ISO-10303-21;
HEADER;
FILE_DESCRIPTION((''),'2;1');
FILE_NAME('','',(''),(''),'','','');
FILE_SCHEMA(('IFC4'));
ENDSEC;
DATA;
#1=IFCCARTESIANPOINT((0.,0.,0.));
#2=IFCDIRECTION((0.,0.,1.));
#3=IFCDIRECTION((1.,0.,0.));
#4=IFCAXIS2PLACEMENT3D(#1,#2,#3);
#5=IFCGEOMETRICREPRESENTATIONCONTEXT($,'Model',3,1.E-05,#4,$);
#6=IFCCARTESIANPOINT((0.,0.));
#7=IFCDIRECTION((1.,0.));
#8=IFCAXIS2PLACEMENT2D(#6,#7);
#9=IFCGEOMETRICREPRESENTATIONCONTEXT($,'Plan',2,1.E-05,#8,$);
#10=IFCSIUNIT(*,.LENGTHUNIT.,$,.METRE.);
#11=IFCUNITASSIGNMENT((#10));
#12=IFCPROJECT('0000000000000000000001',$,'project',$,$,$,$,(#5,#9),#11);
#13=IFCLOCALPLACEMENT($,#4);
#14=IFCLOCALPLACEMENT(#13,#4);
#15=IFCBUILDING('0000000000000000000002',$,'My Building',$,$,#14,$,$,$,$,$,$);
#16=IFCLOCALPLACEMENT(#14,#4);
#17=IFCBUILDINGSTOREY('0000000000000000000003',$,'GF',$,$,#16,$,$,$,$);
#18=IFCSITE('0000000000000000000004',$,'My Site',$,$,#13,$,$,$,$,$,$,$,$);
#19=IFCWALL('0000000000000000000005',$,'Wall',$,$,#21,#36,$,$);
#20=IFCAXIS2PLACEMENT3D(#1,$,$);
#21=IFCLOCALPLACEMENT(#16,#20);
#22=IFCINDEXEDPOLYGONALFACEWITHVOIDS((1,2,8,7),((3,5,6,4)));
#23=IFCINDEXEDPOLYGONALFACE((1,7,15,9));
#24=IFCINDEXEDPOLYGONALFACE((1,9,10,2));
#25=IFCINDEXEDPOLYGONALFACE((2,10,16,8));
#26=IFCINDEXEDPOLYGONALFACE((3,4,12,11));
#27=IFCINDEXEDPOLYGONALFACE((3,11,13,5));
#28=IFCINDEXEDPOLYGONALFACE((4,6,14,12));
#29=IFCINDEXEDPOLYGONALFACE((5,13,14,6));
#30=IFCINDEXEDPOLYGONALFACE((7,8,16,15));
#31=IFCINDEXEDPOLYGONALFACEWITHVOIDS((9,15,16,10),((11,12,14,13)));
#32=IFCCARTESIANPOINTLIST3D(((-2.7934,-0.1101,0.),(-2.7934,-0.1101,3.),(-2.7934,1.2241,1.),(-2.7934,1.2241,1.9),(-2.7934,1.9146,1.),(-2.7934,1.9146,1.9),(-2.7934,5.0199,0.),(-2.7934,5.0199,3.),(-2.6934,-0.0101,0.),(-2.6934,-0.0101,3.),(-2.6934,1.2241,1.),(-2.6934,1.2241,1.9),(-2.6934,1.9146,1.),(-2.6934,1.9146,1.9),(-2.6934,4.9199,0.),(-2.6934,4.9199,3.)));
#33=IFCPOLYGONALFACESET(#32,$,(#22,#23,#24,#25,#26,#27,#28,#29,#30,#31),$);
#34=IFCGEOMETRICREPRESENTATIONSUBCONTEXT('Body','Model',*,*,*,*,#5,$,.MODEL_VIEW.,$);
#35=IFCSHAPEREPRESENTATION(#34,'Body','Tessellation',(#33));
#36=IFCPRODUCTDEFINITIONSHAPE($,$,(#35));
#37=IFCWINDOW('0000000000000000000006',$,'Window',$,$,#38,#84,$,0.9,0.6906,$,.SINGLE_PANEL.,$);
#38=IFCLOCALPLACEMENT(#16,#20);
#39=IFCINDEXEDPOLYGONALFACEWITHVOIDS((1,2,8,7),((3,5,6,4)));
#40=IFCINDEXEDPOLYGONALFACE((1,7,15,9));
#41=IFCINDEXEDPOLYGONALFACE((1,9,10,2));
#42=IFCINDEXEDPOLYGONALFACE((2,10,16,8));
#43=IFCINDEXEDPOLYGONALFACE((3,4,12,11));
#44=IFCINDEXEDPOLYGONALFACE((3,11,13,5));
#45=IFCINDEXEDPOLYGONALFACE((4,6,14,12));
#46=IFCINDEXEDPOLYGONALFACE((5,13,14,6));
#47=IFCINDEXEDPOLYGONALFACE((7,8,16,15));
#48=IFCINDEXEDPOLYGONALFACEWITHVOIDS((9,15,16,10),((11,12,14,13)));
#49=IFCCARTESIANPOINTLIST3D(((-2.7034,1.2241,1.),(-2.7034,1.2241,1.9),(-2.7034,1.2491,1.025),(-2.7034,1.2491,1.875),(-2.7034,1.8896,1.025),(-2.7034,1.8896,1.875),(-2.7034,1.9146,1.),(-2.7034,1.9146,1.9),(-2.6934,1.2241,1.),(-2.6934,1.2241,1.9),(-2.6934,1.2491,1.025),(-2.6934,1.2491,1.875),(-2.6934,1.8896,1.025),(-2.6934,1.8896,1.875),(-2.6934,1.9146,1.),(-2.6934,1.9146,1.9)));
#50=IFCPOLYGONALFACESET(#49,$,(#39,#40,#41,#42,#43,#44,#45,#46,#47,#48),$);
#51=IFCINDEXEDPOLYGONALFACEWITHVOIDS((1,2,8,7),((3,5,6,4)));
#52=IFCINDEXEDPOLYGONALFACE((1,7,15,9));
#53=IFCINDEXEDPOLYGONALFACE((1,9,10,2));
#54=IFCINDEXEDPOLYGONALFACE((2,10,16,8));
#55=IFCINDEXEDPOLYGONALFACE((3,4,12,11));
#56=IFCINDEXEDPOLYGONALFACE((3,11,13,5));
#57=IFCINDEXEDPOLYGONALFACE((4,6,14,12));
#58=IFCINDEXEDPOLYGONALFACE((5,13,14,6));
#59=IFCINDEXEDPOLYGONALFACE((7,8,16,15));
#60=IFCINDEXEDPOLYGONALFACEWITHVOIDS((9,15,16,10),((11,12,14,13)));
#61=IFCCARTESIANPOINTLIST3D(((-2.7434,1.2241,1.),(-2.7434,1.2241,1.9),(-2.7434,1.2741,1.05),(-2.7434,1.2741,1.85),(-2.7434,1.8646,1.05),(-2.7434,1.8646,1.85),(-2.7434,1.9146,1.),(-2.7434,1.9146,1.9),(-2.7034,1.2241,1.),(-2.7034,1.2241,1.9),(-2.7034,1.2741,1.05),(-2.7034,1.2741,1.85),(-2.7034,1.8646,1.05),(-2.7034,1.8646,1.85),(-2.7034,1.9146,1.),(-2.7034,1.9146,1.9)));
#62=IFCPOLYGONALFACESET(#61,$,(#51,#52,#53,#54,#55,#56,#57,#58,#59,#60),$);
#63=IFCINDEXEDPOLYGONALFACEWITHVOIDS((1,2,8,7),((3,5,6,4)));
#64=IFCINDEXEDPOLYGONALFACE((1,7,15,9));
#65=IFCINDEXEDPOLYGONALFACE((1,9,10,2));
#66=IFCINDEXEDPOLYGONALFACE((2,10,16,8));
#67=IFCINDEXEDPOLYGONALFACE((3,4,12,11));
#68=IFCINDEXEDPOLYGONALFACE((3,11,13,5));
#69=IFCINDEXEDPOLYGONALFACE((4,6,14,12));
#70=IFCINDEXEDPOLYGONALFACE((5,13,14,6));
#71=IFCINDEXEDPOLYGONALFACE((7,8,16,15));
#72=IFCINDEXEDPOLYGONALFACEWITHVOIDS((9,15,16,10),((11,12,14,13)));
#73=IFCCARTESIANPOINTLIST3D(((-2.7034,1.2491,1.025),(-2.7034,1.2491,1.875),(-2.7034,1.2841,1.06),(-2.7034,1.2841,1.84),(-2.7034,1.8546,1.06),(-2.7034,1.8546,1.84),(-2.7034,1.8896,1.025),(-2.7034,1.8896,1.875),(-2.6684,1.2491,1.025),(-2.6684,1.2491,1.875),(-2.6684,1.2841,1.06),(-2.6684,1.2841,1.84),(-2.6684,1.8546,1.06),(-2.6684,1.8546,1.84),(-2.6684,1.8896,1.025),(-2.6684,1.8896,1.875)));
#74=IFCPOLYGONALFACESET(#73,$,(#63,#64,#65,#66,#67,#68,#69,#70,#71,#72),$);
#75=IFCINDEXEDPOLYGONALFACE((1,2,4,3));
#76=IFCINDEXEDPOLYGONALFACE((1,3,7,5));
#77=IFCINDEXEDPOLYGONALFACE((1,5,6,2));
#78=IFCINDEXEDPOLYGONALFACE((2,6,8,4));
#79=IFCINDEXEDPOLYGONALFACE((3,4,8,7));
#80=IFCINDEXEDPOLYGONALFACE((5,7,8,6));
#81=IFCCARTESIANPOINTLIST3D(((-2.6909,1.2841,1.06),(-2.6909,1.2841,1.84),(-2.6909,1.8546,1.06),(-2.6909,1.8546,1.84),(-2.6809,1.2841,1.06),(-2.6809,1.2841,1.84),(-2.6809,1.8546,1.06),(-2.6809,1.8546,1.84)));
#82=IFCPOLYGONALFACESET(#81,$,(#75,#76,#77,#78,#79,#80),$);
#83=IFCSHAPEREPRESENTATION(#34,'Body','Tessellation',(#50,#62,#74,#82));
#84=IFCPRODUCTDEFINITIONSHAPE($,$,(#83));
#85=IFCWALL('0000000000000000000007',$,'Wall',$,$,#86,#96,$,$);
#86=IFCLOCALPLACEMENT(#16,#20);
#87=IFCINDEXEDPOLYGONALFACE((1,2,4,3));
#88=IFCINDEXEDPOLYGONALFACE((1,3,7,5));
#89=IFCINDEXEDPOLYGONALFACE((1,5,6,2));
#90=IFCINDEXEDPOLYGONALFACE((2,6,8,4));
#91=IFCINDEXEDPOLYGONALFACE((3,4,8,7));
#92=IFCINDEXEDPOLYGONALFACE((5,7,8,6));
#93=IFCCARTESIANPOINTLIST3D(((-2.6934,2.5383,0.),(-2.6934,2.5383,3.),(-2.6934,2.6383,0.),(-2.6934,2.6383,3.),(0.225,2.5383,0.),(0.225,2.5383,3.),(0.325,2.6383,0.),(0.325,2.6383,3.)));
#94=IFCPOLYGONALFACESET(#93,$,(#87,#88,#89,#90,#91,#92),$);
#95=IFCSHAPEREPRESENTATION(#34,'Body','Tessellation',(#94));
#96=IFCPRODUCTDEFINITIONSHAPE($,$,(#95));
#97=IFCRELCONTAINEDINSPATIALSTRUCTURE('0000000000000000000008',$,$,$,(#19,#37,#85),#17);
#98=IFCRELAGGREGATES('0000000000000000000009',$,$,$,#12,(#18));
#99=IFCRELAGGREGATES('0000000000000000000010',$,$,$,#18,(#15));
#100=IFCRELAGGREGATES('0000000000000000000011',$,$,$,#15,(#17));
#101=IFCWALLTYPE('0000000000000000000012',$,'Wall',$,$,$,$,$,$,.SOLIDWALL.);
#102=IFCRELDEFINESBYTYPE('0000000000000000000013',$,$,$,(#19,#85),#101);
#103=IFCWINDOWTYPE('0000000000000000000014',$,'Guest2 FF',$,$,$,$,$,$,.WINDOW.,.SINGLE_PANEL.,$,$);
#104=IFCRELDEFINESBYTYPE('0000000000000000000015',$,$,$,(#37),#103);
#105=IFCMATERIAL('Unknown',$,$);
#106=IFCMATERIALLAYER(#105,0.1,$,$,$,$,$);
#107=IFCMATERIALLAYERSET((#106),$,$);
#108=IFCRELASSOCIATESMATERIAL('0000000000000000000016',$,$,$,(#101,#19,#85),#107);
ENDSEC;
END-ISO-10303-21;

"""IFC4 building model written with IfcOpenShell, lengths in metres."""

from ifc_helpers import new_model, entity, si_unit, frame, origin_with_axes, origin_2d_with_axis, place, context, subcontext, project, spatial, line, indexed_curve, outline, extrude, shape, source, transform, mapped, material, layer, layer_set, layer_usage, type_object, type_shapes, element, fill, save


model = new_model("IFC4")

# Units and contexts
model_context = context("Model", 3, precision=1e-05, world=origin_with_axes())
plan_context = context("Plan", 2, precision=1e-05, world=origin_2d_with_axis())
body_context_1 = subcontext(model_context, "Body", "Model", "MODEL_VIEW")
body_context_2 = subcontext(plan_context, "Body", "Plan", "PLAN_VIEW")
ifc_project = project(units=[si_unit("LENGTHUNIT", "METRE")], contexts=[model_context, plan_context])

# Site, building, storey
site_placement = place(None, origin_with_axes())
site = spatial("IfcSite", under=ifc_project, at=site_placement, Name="My Site")
building_placement = place(site_placement, origin_with_axes())
building = spatial("IfcBuilding", under=site, at=building_placement, Name="My Building")
storey_placement = place(building_placement, origin_with_axes())
storey = spatial("IfcBuildingStorey", under=building, at=storey_placement, Name="GF")

# Shared definitions
ifc_material_1 = material(Name="Unknown")

# Shared definitions
ifc_layer_1 = layer(ifc_material_1, 0.1)
ifc_layer_set_1 = layer_set([ifc_layer_1])
wall_type = type_object("IfcWallType", Name="Wall", PredefinedType="SOLIDWALL", material=ifc_layer_set_1)

# Wall, opening, window
ifc_layer_usage_1 = layer_usage(ifc_layer_set_1, "AXIS2", "POSITIVE", 0.0)
wall_1_placement = place(storey_placement, frame((-2.7934, 5.0199, 0.0), z_axis=(0.0, 0.0, 1.0), x_axis=(0.0, -1.0, 0.0)))
wall_1 = element("IfcWall", 1, at=wall_1_placement, inside=storey, type_object=wall_type, material=ifc_layer_usage_1, Name="Wall", context=body_context_1, shape_type="SweptSolid", body=[
    extrude(outline(indexed_curve([(0.0, 0.0), (0.1, 0.1), (5.03, 0.1), (5.13, 0.0)], segments=[line(1, 2, 3, 4, 1)])), origin_with_axes(), (0.0, 0.0, 1.0), 3.0),
])
shared_shape_1 = source(origin_with_axes(), body_context_1, "Body", "SweptSolid", [
    extrude(outline(indexed_curve([(0.0, 0.0), (0.6906, 0.0), (0.6906, 0.9), (0.0, 0.9)], segments=[line(1, 2, 3, 4, 1)])), frame((0.0, -0.6, 0.0), z_axis=(0.0, -1.0, 0.0), x_axis=(1.0, 0.0, 0.0)), (0.0, 0.0, -1.0), 1.2),
])
opening_1_placement = place(wall_1_placement, frame((3.1053, 0.0, 1.0), z_axis=(0.0, 0.0, 1.0), x_axis=(1.0, 0.0, 0.0)))
opening_1 = element("IfcOpeningElement", 2, at=opening_1_placement, cuts=wall_1, PredefinedType="OPENING", context=body_context_1, shape_type="MappedRepresentation", body=[
    mapped(shared_shape_1, transform((0.0, 0.0, 0.0), x_axis=(1.0, 0.0, 0.0), y_axis=(0.0, 1.0, 0.0), z_axis=(0.0, 0.0, 1.0), scale=1.0)),
])
window_type_1 = type_object("IfcWindowType", Name="Guest2 FF", PartitioningType="SINGLE_PANEL", PredefinedType="WINDOW")
shared_shape_2 = source(origin_with_axes(), body_context_1, "Body", "SweptSolid", [
    extrude(outline(indexed_curve([(0.0, 0.0), (0.6906, 0.0), (0.6906, 0.9), (0.0, 0.9)], segments=[line(1, 2, 3, 4, 1)]), holes=[indexed_curve([(0.025, 0.025), (0.6656, 0.025), (0.6656, 0.875), (0.025, 0.875)], segments=[line(1, 2, 3, 4, 1)])]), frame((0.0, 0.09, 0.0), z_axis=(0.0, -1.0, 0.0), x_axis=(1.0, 0.0, 0.0)), (0.0, 0.0, -1.0), 0.01),
    extrude(outline(indexed_curve([(0.0, 0.0), (0.6906, 0.0), (0.6906, 0.9), (0.0, 0.9)], segments=[line(1, 2, 3, 4, 1)]), holes=[indexed_curve([(0.05, 0.05), (0.6406, 0.05), (0.6406, 0.85), (0.05, 0.85)], segments=[line(1, 2, 3, 4, 1)])]), frame((0.0, 0.05, 0.0), z_axis=(0.0, -1.0, 0.0), x_axis=(1.0, 0.0, 0.0)), (0.0, 0.0, -1.0), 0.04),
    extrude(outline(indexed_curve([(0.0, 0.0), (0.6406, 0.0), (0.6406, 0.85), (0.0, 0.85)], segments=[line(1, 2, 3, 4, 1)]), holes=[indexed_curve([(0.035, 0.035), (0.6056, 0.035), (0.6056, 0.815), (0.035, 0.815)], segments=[line(1, 2, 3, 4, 1)])]), frame((0.025, 0.09, 0.025), z_axis=(0.0, -1.0, 0.0), x_axis=(1.0, 0.0, 0.0)), (0.0, 0.0, -1.0), 0.035),
    extrude(outline(indexed_curve([(0.035, 0.035), (0.6056, 0.035), (0.6056, 0.815), (0.035, 0.815)], segments=[line(1, 2, 3, 4, 1)])), frame((0.025, 0.1025, 0.025), z_axis=(0.0, -1.0, 0.0), x_axis=(1.0, 0.0, 0.0)), (0.0, 0.0, -1.0), 0.01),
])
shared_shape_3 = source(origin_with_axes(), body_context_2, "Body", "Curve2D", [
    entity("IfcIndexedPolyCurve", entity("IfcCartesianPointList2D", [[0.05, 0.05], [0.6406, 0.05]])),
    entity("IfcIndexedPolyCurve", entity("IfcCartesianPointList2D", [[0.0, 0.1], [0.025, 0.1], [0.025, 0.09], [0.05, 0.09], [0.05, 0.05], [0.0, 0.05]]), [entity("IfcLineIndex", [1, 2, 3, 4, 5, 6, 1])]),
    entity("IfcIndexedPolyCurve", entity("IfcCartesianPointList2D", [[0.6906, 0.1], [0.6656, 0.1], [0.6656, 0.09], [0.6406, 0.09], [0.6406, 0.05], [0.6906, 0.05]]), [entity("IfcLineIndex", [1, 2, 3, 4, 5, 6, 1])]),
    entity("IfcIndexedPolyCurve", entity("IfcCartesianPointList2D", [[0.025, 0.09], [0.06, 0.09], [0.06, 0.125], [0.025, 0.125]]), [entity("IfcLineIndex", [1, 2, 3, 4, 1])]),
    entity("IfcIndexedPolyCurve", entity("IfcCartesianPointList2D", [[0.6656, 0.09], [0.6306, 0.09], [0.6306, 0.125], [0.6656, 0.125]]), [entity("IfcLineIndex", [1, 2, 3, 4, 1])]),
    entity("IfcIndexedPolyCurve", entity("IfcCartesianPointList2D", [[0.06, 0.09], [0.6306, 0.09]])),
    entity("IfcIndexedPolyCurve", entity("IfcCartesianPointList2D", [[0.06, 0.125], [0.6306, 0.125]])),
    entity("IfcIndexedPolyCurve", entity("IfcCartesianPointList2D", [[0.06, 0.1075], [0.6306, 0.1075]])),
])
type_shapes(window_type_1, [shared_shape_2, shared_shape_3])
window_1_placement = place(opening_1_placement, frame((0.0, 0.0, 0.0), z_axis=(0.0, 0.0, 1.0), x_axis=(1.0, 0.0, 0.0)))
window_1 = element("IfcWindow", 3, at=window_1_placement, inside=storey, type_object=window_type_1, Name="Window", OverallHeight=0.9, OverallWidth=0.6906, PartitioningType="SINGLE_PANEL", shapes=[
    shape(body_context_1, "Body", "MappedRepresentation", [mapped(shared_shape_2, transform((0.0, 0.0, 0.0), x_axis=(1.0, 0.0, 0.0), y_axis=(0.0, 1.0, 0.0), z_axis=(0.0, 0.0, 1.0), scale=1.0))]),
    shape(body_context_2, "Body", "MappedRepresentation", [mapped(shared_shape_3, transform((0.0, 0.0, 0.0), x_axis=(1.0, 0.0, 0.0), y_axis=(0.0, 1.0, 0.0), z_axis=(0.0, 0.0, 1.0), scale=1.0))]),
])
fill(opening_1, window_1)

# Wall
ifc_layer_usage_2 = layer_usage(ifc_layer_set_1, "AXIS2", "POSITIVE", 0.0)
wall_2_placement = place(storey_placement, frame((0.325, 2.6383, 0.0), z_axis=(0.0, 0.0, 1.0), x_axis=(-1.0, 0.0, 0.0)))
element("IfcWall", 4, at=wall_2_placement, inside=storey, type_object=wall_type, material=ifc_layer_usage_2, Name="Wall", context=body_context_1, shape_type="SweptSolid", body=[
    extrude(outline(indexed_curve([(0.0, 0.0), (0.1, 0.1), (3.0184, 0.1), (3.0184, 0.0)], segments=[line(1, 2, 3, 4, 1)])), origin_with_axes(), (0.0, 0.0, 1.0), 3.0),
])

save(model, "model.ifc")
